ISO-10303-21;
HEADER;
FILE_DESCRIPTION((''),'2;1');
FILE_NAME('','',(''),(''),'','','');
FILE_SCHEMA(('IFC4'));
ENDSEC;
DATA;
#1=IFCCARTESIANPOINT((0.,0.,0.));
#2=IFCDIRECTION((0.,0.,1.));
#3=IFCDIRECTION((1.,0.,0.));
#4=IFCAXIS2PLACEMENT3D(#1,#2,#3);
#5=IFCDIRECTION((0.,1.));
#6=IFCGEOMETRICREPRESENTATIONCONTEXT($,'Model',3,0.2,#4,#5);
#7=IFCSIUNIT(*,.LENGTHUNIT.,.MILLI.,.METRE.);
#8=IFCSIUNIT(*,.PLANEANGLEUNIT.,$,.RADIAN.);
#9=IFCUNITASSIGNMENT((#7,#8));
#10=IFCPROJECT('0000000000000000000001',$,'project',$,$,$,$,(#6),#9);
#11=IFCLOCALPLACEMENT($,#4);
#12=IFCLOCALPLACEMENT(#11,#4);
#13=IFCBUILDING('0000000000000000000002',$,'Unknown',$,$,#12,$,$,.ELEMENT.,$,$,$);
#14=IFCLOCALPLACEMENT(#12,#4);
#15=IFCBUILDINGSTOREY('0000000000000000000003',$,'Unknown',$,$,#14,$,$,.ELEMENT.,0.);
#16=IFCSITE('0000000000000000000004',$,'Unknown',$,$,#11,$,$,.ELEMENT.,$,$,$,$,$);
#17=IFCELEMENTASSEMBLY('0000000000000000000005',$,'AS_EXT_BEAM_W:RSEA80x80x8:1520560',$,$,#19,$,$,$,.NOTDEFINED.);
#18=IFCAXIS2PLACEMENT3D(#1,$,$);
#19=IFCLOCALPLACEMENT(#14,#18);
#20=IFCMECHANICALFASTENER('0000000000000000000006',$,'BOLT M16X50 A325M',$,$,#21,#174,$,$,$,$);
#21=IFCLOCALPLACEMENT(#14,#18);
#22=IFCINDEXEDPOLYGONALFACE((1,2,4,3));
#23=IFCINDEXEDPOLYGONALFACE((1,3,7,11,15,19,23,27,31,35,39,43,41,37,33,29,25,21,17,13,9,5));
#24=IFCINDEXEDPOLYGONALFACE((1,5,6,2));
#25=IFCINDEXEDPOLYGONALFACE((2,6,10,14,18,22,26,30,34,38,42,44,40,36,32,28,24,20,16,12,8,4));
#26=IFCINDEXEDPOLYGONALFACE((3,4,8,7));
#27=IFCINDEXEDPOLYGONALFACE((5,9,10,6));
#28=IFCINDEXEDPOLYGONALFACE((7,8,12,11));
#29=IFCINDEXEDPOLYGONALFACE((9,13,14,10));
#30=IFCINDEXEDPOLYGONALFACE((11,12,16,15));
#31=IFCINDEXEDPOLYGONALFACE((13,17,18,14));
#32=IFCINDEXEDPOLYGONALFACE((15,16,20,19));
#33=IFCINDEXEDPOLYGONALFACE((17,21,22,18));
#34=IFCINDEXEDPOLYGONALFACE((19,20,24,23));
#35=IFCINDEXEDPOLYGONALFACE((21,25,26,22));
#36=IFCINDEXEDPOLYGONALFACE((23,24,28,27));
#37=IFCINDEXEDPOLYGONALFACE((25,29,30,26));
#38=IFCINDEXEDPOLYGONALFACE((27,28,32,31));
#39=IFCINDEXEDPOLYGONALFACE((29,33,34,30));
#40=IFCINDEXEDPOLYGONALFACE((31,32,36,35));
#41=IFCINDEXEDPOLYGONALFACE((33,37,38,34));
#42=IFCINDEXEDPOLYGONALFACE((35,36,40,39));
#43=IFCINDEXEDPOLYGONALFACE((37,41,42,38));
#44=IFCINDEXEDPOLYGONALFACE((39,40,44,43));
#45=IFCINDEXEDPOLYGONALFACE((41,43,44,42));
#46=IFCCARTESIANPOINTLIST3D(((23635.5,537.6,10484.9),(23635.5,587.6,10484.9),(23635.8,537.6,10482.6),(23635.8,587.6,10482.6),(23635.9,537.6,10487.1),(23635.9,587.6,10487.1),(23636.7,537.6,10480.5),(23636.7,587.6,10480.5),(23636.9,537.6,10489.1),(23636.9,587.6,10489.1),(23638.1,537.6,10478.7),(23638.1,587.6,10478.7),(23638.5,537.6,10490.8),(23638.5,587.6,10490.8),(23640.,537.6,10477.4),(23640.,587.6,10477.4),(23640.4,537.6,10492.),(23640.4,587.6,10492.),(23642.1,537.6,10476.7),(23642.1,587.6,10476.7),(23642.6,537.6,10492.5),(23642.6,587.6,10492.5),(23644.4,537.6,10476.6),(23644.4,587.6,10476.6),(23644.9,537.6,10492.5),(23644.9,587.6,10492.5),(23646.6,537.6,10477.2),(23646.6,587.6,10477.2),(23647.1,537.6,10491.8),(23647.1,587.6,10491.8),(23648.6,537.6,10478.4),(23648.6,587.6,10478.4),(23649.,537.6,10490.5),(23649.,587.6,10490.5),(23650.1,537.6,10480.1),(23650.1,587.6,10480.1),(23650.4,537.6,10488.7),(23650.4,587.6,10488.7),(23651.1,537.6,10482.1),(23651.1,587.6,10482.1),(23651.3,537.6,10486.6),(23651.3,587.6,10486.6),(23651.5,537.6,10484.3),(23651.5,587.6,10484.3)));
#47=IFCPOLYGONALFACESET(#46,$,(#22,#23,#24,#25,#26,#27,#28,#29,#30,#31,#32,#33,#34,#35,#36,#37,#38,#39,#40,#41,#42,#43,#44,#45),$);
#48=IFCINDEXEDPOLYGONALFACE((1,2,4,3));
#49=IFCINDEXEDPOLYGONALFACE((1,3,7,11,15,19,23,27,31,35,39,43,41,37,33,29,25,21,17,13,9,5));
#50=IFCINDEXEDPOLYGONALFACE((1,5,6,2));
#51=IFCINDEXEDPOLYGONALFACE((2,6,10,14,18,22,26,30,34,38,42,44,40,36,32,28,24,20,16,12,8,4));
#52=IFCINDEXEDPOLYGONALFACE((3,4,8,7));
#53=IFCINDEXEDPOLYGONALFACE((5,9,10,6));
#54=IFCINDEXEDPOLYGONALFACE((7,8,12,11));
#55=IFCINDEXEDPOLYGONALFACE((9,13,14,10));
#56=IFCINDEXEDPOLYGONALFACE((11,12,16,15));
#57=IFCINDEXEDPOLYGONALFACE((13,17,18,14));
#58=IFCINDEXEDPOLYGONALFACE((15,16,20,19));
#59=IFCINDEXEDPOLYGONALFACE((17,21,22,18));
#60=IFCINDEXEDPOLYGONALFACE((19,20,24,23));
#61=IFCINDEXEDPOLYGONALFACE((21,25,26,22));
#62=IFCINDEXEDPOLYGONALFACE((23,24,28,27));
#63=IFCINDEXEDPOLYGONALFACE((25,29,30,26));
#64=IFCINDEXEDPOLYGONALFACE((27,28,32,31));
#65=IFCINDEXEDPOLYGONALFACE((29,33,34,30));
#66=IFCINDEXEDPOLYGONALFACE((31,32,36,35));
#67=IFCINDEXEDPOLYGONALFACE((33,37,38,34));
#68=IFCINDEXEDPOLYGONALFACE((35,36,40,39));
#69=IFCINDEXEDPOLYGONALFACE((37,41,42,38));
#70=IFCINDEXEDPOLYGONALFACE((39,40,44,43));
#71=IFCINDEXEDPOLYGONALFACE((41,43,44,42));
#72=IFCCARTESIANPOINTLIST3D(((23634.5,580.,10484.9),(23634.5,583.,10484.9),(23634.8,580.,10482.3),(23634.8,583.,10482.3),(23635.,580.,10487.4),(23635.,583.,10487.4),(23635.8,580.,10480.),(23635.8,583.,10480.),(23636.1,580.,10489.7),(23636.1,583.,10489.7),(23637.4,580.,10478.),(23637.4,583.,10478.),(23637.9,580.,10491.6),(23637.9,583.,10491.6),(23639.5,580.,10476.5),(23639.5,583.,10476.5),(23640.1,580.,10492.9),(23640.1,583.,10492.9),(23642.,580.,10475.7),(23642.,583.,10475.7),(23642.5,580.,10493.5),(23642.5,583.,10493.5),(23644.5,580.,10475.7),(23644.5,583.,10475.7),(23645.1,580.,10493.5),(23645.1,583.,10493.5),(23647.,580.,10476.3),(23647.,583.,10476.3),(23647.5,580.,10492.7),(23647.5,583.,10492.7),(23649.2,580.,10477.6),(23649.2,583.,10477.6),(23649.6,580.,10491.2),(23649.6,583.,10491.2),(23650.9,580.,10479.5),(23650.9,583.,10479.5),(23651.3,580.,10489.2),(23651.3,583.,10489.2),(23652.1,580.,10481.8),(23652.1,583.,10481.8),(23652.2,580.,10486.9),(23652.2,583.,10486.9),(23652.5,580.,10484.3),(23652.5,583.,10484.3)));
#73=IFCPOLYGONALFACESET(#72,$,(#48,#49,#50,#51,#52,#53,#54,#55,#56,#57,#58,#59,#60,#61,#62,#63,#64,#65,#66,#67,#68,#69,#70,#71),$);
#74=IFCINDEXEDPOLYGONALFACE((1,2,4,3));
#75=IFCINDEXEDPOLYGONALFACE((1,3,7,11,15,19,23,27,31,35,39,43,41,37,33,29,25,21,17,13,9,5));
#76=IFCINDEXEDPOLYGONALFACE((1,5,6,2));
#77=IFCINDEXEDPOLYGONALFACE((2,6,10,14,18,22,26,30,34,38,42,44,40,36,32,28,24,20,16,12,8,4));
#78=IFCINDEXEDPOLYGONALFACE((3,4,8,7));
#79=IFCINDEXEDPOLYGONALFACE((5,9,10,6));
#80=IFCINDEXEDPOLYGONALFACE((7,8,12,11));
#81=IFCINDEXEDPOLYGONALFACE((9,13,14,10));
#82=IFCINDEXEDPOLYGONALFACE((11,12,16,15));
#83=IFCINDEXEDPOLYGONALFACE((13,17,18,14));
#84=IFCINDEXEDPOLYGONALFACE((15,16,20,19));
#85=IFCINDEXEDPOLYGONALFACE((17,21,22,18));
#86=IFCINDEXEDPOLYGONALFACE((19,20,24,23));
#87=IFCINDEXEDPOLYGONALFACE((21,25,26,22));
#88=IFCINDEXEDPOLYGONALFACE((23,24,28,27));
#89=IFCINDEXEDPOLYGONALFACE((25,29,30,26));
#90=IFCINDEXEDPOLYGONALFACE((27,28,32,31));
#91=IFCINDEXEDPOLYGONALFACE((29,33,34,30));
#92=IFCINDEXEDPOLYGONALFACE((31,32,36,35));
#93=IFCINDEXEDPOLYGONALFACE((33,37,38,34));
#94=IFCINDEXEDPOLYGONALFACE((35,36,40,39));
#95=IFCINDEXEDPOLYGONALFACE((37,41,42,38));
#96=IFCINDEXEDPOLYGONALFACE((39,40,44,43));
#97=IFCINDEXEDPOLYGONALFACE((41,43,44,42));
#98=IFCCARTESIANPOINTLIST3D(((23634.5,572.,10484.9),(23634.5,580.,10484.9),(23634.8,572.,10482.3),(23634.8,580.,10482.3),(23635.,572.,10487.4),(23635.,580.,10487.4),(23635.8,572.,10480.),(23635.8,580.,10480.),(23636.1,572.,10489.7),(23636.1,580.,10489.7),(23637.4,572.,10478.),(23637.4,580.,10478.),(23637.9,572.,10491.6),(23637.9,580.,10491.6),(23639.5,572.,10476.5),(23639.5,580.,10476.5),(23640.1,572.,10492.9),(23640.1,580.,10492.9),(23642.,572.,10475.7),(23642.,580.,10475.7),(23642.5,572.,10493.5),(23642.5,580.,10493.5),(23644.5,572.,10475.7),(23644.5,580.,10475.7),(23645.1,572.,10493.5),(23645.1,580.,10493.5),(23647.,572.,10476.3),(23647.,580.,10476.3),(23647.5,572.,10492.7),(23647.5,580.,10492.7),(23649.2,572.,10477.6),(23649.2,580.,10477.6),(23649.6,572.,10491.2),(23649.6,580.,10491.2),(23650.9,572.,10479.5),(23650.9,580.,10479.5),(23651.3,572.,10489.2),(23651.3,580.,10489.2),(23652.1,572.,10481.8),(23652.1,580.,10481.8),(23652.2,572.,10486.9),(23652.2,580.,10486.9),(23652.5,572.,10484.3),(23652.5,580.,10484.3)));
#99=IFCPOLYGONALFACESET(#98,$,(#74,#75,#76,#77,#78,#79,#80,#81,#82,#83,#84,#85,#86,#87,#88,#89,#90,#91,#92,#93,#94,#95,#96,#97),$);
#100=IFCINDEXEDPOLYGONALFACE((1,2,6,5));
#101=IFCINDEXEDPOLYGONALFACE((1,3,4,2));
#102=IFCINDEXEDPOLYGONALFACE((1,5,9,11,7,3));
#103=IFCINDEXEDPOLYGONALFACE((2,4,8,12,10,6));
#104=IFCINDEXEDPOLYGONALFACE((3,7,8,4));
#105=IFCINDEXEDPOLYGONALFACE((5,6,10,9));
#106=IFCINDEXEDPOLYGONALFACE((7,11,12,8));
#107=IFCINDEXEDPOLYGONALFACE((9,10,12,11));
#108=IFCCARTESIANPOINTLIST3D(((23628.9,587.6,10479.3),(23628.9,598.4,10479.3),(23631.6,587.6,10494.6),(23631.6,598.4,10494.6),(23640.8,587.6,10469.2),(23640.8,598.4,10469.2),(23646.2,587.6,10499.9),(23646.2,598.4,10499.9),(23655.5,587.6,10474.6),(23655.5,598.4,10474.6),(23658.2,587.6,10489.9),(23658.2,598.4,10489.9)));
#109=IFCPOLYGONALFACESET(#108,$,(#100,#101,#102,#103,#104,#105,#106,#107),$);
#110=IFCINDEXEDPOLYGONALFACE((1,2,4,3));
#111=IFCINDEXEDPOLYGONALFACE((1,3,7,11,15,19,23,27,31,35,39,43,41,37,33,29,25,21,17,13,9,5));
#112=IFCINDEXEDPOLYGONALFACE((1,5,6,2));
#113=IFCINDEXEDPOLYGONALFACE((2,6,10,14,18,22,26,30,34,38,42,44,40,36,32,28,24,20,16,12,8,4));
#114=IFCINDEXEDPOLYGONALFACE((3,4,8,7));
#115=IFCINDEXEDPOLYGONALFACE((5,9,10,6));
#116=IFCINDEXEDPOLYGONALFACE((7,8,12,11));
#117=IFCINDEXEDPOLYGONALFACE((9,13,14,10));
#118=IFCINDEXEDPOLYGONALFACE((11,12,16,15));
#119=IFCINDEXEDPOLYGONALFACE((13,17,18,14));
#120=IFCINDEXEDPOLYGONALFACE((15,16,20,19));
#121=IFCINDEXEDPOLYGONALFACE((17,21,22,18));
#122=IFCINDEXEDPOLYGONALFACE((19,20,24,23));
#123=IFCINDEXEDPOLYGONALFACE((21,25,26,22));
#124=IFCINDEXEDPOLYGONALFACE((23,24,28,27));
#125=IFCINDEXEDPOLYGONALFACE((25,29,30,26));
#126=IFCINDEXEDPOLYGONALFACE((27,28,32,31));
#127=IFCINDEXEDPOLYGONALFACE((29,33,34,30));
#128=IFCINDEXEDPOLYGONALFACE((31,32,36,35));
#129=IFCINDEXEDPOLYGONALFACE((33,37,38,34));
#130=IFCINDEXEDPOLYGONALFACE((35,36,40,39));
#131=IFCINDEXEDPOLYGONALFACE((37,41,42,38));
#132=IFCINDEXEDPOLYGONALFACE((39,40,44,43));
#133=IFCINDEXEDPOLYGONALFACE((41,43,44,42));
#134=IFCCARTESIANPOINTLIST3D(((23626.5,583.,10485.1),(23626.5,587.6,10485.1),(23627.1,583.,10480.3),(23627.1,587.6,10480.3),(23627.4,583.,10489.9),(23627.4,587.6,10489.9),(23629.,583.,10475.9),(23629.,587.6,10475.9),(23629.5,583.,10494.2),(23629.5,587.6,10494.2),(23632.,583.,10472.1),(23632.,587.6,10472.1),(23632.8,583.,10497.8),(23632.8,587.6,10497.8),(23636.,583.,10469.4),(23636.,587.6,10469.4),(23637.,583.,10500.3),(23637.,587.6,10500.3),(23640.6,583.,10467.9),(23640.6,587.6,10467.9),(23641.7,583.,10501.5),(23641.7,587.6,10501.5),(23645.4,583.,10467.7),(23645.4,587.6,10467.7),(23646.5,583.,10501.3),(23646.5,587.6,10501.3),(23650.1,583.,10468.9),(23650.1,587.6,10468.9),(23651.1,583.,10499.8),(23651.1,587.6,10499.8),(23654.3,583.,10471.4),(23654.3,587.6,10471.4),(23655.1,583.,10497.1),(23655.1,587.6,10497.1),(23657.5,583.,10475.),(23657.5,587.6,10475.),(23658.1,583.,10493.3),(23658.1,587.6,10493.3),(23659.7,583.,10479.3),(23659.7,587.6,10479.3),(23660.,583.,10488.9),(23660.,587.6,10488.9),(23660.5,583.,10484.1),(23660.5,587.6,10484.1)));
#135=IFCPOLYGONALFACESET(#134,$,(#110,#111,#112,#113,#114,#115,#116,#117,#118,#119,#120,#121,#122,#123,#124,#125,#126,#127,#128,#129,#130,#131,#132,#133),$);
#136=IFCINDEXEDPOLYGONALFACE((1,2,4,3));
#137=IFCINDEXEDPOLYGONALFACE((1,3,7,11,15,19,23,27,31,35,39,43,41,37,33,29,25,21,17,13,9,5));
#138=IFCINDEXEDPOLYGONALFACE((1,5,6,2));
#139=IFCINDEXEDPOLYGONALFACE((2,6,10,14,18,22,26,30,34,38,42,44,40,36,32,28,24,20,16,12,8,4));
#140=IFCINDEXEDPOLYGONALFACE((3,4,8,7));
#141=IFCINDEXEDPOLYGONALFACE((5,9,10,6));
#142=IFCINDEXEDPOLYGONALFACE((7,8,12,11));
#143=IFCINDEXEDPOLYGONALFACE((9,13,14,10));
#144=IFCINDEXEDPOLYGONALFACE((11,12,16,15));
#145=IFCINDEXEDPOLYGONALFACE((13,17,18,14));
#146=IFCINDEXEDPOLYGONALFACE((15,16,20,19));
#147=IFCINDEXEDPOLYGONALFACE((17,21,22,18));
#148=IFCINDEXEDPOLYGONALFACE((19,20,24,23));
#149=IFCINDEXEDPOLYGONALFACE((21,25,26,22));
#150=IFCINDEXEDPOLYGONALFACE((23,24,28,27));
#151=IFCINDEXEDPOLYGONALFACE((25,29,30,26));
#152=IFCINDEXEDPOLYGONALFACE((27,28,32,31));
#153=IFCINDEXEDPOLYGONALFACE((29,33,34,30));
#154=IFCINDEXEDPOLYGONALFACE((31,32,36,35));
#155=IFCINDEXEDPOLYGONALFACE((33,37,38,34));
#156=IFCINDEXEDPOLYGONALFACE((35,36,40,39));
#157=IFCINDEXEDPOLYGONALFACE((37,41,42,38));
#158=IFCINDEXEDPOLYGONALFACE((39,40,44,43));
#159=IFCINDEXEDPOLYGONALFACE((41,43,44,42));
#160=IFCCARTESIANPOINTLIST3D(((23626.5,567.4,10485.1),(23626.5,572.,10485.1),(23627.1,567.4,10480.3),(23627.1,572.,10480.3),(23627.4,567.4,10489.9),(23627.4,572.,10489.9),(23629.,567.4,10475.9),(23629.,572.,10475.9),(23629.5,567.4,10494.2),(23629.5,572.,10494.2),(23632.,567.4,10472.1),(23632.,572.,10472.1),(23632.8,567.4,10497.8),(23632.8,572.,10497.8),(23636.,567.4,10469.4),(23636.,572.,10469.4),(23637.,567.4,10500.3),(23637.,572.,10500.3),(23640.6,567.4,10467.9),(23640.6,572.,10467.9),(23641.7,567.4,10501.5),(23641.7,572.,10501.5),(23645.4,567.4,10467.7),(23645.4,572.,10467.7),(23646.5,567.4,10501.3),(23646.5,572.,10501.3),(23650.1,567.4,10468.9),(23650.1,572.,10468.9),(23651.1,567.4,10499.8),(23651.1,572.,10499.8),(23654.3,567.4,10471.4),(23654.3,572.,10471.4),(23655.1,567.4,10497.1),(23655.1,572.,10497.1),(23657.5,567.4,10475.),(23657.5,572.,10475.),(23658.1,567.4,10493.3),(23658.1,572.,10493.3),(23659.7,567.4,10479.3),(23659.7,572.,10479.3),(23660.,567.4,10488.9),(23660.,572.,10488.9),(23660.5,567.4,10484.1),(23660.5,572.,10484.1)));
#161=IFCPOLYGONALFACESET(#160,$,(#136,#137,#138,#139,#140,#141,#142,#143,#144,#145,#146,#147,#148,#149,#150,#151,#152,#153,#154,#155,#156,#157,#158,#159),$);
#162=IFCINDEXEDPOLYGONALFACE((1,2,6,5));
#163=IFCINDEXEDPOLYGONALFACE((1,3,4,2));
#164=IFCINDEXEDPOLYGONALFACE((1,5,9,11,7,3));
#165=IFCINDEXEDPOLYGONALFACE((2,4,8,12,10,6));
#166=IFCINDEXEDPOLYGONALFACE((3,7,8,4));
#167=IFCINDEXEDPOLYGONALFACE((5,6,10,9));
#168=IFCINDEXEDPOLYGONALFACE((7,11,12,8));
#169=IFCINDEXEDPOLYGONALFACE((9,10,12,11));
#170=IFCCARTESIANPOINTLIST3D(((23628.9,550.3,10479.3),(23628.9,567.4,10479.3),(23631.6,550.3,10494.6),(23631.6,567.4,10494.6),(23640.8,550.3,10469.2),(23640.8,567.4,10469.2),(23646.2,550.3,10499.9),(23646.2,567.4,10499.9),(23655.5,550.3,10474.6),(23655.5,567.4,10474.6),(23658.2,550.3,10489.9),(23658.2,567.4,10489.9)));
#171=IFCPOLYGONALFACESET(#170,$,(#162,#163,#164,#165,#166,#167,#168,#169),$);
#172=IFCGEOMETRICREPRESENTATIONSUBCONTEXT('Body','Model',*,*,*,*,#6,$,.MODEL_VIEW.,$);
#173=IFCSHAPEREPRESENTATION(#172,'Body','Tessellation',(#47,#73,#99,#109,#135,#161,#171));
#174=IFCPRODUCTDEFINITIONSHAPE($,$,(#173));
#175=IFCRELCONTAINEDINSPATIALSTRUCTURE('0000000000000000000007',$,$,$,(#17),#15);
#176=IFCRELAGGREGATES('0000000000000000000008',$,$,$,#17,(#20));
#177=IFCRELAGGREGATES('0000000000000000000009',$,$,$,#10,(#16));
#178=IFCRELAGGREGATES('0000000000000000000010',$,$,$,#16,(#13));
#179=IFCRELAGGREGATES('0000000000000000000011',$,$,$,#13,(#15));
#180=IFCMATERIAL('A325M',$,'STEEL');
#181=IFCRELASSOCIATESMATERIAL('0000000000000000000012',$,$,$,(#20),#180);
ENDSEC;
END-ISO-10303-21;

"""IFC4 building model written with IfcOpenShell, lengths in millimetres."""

from ifc_helpers import new_model, si_unit, direction, frame, origin_with_axes, place, context, subcontext, project, spatial, line, arc, indexed_curve, outline, extrude, source, transform, mapped, material, element, aggregate, save


model = new_model("IFC4")

# Units and contexts
model_context = context("Model", 3, precision=0.2, world=origin_with_axes(), true_north=direction((0.0, 1.0)))
body_context = subcontext(model_context, "Body", "Model", "MODEL_VIEW")
ifc_project = project(units=[si_unit("LENGTHUNIT", "METRE", prefix="MILLI"), si_unit("PLANEANGLEUNIT", "RADIAN")], contexts=[model_context])

# Site, building, storey
site_placement = place(None, origin_with_axes())
site = spatial("IfcSite", under=ifc_project, at=site_placement, Name="Unknown", CompositionType="ELEMENT")
building_placement = place(site_placement, origin_with_axes())
building = spatial("IfcBuilding", under=site, at=building_placement, Name="Unknown", CompositionType="ELEMENT")
storey_placement = place(building_placement, origin_with_axes())
storey = spatial("IfcBuildingStorey", under=building, at=storey_placement, Name="Unknown", CompositionType="ELEMENT", Elevation=0.0)

# Element assembly
assembly_1_placement = place(storey_placement, frame((23581.1, 540.0, 10490.5), z_axis=(0.0, -1.0, 0.0), x_axis=(0.984808, 0.0, -0.173648)))
assembly_1 = element("IfcElementAssembly", 1, at=assembly_1_placement, inside=storey, Name="AS_EXT_BEAM_W:RSEA80x80x8:1520560", PredefinedType="NOTDEFINED")

# Mechanical fastener
ifc_material_1 = material(Name="A325M", Category="STEEL")
shared_shape = source(origin_with_axes(), body_context, "Body", "SweptSolid", [
    extrude(outline(indexed_curve([(8.0, 0.0), (0.0, 8.0), (-8.0, 0.0), (0.0, -8.0)], segments=[arc(1, 2, 3), arc(3, 4, 1)])), frame((0.0, 0.0, 15.6), z_axis=(0.0, 0.0, -1.0), x_axis=(0.0, 1.0, 0.0)), (0.0, 0.0, 1.0), 50.0),
    extrude(outline(indexed_curve([(9.0, 0.0), (0.0, 9.0), (-9.0, 0.0), (0.0, -9.0)], segments=[arc(1, 2, 3), arc(3, 4, 1)])), frame((0.0, 0.0, 11.0), z_axis=(0.0, 0.0, -1.0), x_axis=(0.0, 1.0, 0.0)), (0.0, 0.0, 1.0), 3.0),
    extrude(outline(indexed_curve([(9.0, 0.0), (0.0, 9.0), (-9.0, 0.0), (0.0, -9.0)], segments=[arc(1, 2, 3), arc(3, 4, 1)])), frame((0.0, 0.0, 8.0), z_axis=(0.0, 0.0, -1.0), x_axis=(0.0, 1.0, 0.0)), (0.0, 0.0, 1.0), 8.0),
    extrude(outline(indexed_curve([(15.6, 0.0), (7.8, 13.5), (-7.8, 13.5), (-15.6, 0.0), (-7.8, -13.5), (7.8, -13.5)], segments=[line(1, 2, 3, 4, 5, 6, 1)])), frame((0.0, 0.0, 26.4), z_axis=(0.0, 0.0, -1.0), x_axis=(0.0, 1.0, 0.0)), (0.0, 0.0, 1.0), 10.8),
    extrude(outline(indexed_curve([(17.0, 0.0), (0.0, 17.0), (-17.0, 0.0), (0.0, -17.0)], segments=[arc(1, 2, 3), arc(3, 4, 1)])), frame((0.0, 0.0, 15.6), z_axis=(0.0, 0.0, -1.0), x_axis=(0.0, 1.0, 0.0)), (0.0, 0.0, 1.0), 4.6),
    extrude(outline(indexed_curve([(17.0, 0.0), (0.0, 17.0), (-17.0, 0.0), (0.0, -17.0)], segments=[arc(1, 2, 3), arc(3, 4, 1)])), frame((0.0, 0.0, 0.0), z_axis=(0.0, 0.0, -1.0), x_axis=(0.0, 1.0, 0.0)), (0.0, 0.0, 1.0), 4.6),
    extrude(outline(indexed_curve([(15.6, 0.0), (7.8, 13.5), (-7.8, 13.5), (-15.6, 0.0), (-7.8, -13.5), (7.8, -13.5)], segments=[line(1, 2, 3, 4, 5, 6, 1)])), frame((0.0, 0.0, -4.6), z_axis=(0.0, 0.0, -1.0), x_axis=(0.0, 1.0, 0.0)), (0.0, 0.0, 1.0), 17.1),
])
mechanical_fastener_1_placement = place(assembly_1_placement, frame((62.5, 5.0, -32.0), z_axis=(0.0, 0.0, -1.0), x_axis=(1.0, 0.0, 0.0)))
mechanical_fastener_1 = element("IfcMechanicalFastener", 2, at=mechanical_fastener_1_placement, material=ifc_material_1, Name="BOLT M16X50 A325M", context=body_context, shape_type="MappedRepresentation", body=[
    mapped(shared_shape, transform((0.0, 0.0, 0.0))),
])
aggregate(assembly_1, [mechanical_fastener_1])

save(model, "model.ifc")
